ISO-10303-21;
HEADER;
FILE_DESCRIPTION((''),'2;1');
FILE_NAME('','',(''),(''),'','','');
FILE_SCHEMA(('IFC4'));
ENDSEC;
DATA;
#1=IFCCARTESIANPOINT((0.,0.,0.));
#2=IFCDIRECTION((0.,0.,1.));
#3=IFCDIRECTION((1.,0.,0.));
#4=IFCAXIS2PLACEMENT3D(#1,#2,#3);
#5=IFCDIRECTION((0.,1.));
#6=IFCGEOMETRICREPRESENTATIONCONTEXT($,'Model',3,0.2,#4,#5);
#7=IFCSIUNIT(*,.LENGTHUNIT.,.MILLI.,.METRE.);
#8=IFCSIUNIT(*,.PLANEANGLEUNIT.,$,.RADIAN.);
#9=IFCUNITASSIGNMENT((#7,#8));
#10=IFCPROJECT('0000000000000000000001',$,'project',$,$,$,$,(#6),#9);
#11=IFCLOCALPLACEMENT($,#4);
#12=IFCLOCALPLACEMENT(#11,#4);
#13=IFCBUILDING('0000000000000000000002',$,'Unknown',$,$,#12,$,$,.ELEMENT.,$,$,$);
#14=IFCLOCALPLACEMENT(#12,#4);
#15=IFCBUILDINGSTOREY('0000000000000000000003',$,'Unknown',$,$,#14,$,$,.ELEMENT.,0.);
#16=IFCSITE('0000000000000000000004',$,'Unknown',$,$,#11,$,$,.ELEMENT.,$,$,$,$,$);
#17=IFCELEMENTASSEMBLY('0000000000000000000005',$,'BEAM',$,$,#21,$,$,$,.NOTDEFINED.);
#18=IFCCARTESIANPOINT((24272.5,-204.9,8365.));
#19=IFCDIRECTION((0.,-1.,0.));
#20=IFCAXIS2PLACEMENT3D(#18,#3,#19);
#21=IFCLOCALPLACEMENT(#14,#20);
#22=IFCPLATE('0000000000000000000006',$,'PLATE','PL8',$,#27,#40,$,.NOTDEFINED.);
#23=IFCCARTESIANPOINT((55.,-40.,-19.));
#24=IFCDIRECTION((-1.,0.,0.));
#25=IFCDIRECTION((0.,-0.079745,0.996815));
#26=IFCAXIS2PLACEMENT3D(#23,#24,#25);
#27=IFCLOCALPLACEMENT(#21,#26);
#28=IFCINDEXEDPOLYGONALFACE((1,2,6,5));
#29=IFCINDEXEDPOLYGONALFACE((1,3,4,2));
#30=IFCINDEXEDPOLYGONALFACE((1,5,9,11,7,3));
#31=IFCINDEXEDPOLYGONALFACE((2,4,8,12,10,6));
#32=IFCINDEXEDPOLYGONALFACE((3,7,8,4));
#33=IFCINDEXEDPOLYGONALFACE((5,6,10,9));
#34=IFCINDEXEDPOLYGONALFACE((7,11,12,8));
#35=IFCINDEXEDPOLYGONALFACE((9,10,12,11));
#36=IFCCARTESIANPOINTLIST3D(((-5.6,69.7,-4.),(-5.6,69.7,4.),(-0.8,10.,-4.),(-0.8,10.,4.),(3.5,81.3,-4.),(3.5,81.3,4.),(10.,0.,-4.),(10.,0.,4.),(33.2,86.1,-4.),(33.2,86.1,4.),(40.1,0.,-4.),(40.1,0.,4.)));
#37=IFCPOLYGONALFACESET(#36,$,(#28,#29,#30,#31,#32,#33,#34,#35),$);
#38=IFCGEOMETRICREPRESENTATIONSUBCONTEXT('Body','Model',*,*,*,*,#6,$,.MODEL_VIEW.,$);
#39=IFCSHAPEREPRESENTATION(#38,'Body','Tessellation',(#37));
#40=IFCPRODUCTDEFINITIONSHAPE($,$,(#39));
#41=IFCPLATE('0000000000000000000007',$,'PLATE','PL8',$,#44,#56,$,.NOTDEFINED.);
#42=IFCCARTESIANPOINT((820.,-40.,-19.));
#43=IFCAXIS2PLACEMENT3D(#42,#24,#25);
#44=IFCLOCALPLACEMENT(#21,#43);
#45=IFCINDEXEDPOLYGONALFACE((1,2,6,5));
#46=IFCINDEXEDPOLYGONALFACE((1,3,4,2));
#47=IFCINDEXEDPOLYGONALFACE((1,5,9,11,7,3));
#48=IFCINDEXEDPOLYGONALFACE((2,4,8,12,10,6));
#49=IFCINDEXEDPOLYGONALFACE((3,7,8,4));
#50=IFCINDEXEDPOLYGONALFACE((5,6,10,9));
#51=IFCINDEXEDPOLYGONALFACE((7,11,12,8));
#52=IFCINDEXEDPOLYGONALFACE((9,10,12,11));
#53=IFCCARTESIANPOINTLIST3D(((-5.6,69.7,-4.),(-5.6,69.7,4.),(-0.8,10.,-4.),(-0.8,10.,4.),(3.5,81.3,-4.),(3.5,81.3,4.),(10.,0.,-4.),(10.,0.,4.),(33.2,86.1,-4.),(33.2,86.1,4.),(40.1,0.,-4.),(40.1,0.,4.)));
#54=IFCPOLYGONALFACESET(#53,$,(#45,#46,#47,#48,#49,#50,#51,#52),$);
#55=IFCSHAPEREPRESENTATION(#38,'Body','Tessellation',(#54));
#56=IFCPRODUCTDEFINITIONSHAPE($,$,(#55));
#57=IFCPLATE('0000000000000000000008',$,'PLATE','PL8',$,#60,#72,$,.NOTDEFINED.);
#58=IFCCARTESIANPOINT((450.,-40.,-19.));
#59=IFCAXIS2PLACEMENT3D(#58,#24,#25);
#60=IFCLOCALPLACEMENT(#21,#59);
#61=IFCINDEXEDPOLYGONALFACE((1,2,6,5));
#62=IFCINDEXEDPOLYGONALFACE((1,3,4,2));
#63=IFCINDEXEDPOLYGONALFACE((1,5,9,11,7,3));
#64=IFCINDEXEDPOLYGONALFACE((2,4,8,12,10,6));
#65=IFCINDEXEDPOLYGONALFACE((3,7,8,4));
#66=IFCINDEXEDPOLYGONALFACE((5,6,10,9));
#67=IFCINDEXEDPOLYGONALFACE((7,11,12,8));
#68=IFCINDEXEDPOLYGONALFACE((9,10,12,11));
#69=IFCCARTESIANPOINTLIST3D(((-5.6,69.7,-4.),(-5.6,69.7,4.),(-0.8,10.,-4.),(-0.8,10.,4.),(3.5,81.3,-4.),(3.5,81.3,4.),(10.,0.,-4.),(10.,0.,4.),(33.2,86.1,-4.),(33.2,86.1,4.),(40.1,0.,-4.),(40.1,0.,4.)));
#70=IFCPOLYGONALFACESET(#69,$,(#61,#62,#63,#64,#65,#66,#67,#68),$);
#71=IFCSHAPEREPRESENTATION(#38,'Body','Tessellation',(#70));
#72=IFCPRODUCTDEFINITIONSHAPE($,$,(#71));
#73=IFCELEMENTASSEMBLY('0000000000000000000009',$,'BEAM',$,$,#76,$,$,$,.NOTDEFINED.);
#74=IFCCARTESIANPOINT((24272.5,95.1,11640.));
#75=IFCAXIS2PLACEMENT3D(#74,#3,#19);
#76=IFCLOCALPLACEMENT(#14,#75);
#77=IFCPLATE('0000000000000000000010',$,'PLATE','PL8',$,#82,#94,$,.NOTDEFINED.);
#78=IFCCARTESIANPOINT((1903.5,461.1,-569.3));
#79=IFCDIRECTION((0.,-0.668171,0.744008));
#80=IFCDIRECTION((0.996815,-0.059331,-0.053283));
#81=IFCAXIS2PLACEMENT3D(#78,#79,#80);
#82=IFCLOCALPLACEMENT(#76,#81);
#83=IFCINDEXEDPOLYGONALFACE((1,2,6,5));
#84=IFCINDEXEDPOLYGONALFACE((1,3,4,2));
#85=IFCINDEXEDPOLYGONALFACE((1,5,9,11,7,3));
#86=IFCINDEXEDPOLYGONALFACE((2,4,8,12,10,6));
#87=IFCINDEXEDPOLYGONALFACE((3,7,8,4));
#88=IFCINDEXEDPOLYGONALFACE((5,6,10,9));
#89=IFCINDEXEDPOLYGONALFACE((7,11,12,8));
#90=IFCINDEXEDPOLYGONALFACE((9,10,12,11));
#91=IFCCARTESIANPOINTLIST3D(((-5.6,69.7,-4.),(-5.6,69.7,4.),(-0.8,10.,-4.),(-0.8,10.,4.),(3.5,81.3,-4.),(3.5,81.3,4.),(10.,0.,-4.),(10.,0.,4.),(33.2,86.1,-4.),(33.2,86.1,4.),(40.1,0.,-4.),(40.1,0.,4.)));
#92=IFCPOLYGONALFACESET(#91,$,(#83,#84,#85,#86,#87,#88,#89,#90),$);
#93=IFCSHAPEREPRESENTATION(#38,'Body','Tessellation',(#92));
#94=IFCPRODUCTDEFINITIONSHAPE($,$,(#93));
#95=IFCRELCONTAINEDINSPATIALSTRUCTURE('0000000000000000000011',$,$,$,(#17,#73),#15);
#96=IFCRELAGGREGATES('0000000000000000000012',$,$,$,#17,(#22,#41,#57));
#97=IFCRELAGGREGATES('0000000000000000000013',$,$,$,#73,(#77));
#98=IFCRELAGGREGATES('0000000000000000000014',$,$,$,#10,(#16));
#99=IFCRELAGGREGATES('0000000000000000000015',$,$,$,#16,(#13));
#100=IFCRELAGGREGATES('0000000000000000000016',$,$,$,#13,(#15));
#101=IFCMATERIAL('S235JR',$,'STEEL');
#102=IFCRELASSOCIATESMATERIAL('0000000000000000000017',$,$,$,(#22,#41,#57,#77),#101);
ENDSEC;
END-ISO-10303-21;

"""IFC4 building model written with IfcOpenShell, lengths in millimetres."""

from ifc_helpers import new_model, si_unit, direction, frame, origin_with_axes, place, context, subcontext, project, spatial, line, indexed_curve, outline, extrude, material, element, aggregate, save


model = new_model("IFC4")

# Units and contexts
model_context = context("Model", 3, precision=0.2, world=origin_with_axes(), true_north=direction((0.0, 1.0)))
body_context = subcontext(model_context, "Body", "Model", "MODEL_VIEW")
ifc_project = project(units=[si_unit("LENGTHUNIT", "METRE", prefix="MILLI"), si_unit("PLANEANGLEUNIT", "RADIAN")], contexts=[model_context])

# Site, building, storey
site_placement = place(None, origin_with_axes())
site = spatial("IfcSite", under=ifc_project, at=site_placement, Name="Unknown", CompositionType="ELEMENT")
building_placement = place(site_placement, origin_with_axes())
building = spatial("IfcBuilding", under=site, at=building_placement, Name="Unknown", CompositionType="ELEMENT")
storey_placement = place(building_placement, origin_with_axes())
storey = spatial("IfcBuildingStorey", under=building, at=storey_placement, Name="Unknown", CompositionType="ELEMENT", Elevation=0.0)

# Shared definitions
ifc_material_1 = material(Name="S235JR", Category="STEEL")

# Element assembly
assembly_1_placement = place(storey_placement, frame((24272.5, -204.9, 8365.0), z_axis=(1.0, 0.0, 0.0), x_axis=(0.0, -1.0, 0.0)))
assembly_1 = element("IfcElementAssembly", 1, at=assembly_1_placement, inside=storey, Name="BEAM", PredefinedType="NOTDEFINED")

# Plates
plate_1_placement = place(assembly_1_placement, frame((55.0, -40.0, -19.0), z_axis=(-1.0, 0.0, 0.0), x_axis=(0.0, -0.079745, 0.996815)))
plate_1 = element("IfcPlate", 2, at=plate_1_placement, material=ifc_material_1, Name="PLATE", Description="PL8", PredefinedType="NOTDEFINED", context=body_context, shape_type="SolidModel", body=[
    extrude(outline(indexed_curve([(-0.8, 10.0), (10.0, 0.0), (40.1, 0.0), (33.2, 86.1), (3.5, 81.3), (-5.6, 69.7)], segments=[line(1, 2, 3, 4, 5, 6, 1)])), frame((0.0, 0.0, 4.0), z_axis=(0.0, 0.0, 1.0), x_axis=(1.0, 0.0, 0.0)), (0.0, 0.0, -1.0), 8.0),
])
plate_2_placement = place(assembly_1_placement, frame((820.0, -40.0, -19.0), z_axis=(-1.0, 0.0, 0.0), x_axis=(0.0, -0.079745, 0.996815)))
plate_2 = element("IfcPlate", 3, at=plate_2_placement, material=ifc_material_1, Name="PLATE", Description="PL8", PredefinedType="NOTDEFINED", context=body_context, shape_type="SolidModel", body=[
    extrude(outline(indexed_curve([(-0.8, 10.0), (10.0, 0.0), (40.1, 0.0), (33.2, 86.1), (3.5, 81.3), (-5.6, 69.7)], segments=[line(1, 2, 3, 4, 5, 6, 1)])), frame((0.0, 0.0, 4.0), z_axis=(0.0, 0.0, 1.0), x_axis=(1.0, 0.0, 0.0)), (0.0, 0.0, -1.0), 8.0),
])
plate_3_placement = place(assembly_1_placement, frame((450.0, -40.0, -19.0), z_axis=(-1.0, 0.0, 0.0), x_axis=(0.0, -0.079745, 0.996815)))
plate_3 = element("IfcPlate", 4, at=plate_3_placement, material=ifc_material_1, Name="PLATE", Description="PL8", PredefinedType="NOTDEFINED", context=body_context, shape_type="SolidModel", body=[
    extrude(outline(indexed_curve([(-0.8, 10.0), (10.0, 0.0), (40.1, 0.0), (33.2, 86.1), (3.5, 81.3), (-5.6, 69.7)], segments=[line(1, 2, 3, 4, 5, 6, 1)])), frame((0.0, 0.0, 4.0), z_axis=(0.0, 0.0, 1.0), x_axis=(1.0, 0.0, 0.0)), (0.0, 0.0, -1.0), 8.0),
])
aggregate(assembly_1, [plate_1, plate_2, plate_3])

# Element assembly, plate
assembly_2_placement = place(storey_placement, frame((24272.5, 95.1, 11640.0), z_axis=(1.0, 0.0, 0.0), x_axis=(0.0, -1.0, 0.0)))
assembly_2 = element("IfcElementAssembly", 5, at=assembly_2_placement, inside=storey, Name="BEAM", PredefinedType="NOTDEFINED")
plate_4_placement = place(assembly_2_placement, frame((1903.5, 461.1, -569.3), z_axis=(0.0, -0.668171, 0.744008), x_axis=(0.996815, -0.059331, -0.053283)))
plate_4 = element("IfcPlate", 6, at=plate_4_placement, material=ifc_material_1, Name="PLATE", Description="PL8", PredefinedType="NOTDEFINED", context=body_context, shape_type="SolidModel", body=[
    extrude(outline(indexed_curve([(-0.8, 10.0), (10.0, 0.0), (40.1, 0.0), (33.2, 86.1), (3.5, 81.3), (-5.6, 69.7)], segments=[line(1, 2, 3, 4, 5, 6, 1)])), frame((0.0, 0.0, 4.0), z_axis=(0.0, 0.0, 1.0), x_axis=(1.0, 0.0, 0.0)), (0.0, 0.0, -1.0), 8.0),
])
aggregate(assembly_2, [plate_4])

save(model, "model.ifc")
